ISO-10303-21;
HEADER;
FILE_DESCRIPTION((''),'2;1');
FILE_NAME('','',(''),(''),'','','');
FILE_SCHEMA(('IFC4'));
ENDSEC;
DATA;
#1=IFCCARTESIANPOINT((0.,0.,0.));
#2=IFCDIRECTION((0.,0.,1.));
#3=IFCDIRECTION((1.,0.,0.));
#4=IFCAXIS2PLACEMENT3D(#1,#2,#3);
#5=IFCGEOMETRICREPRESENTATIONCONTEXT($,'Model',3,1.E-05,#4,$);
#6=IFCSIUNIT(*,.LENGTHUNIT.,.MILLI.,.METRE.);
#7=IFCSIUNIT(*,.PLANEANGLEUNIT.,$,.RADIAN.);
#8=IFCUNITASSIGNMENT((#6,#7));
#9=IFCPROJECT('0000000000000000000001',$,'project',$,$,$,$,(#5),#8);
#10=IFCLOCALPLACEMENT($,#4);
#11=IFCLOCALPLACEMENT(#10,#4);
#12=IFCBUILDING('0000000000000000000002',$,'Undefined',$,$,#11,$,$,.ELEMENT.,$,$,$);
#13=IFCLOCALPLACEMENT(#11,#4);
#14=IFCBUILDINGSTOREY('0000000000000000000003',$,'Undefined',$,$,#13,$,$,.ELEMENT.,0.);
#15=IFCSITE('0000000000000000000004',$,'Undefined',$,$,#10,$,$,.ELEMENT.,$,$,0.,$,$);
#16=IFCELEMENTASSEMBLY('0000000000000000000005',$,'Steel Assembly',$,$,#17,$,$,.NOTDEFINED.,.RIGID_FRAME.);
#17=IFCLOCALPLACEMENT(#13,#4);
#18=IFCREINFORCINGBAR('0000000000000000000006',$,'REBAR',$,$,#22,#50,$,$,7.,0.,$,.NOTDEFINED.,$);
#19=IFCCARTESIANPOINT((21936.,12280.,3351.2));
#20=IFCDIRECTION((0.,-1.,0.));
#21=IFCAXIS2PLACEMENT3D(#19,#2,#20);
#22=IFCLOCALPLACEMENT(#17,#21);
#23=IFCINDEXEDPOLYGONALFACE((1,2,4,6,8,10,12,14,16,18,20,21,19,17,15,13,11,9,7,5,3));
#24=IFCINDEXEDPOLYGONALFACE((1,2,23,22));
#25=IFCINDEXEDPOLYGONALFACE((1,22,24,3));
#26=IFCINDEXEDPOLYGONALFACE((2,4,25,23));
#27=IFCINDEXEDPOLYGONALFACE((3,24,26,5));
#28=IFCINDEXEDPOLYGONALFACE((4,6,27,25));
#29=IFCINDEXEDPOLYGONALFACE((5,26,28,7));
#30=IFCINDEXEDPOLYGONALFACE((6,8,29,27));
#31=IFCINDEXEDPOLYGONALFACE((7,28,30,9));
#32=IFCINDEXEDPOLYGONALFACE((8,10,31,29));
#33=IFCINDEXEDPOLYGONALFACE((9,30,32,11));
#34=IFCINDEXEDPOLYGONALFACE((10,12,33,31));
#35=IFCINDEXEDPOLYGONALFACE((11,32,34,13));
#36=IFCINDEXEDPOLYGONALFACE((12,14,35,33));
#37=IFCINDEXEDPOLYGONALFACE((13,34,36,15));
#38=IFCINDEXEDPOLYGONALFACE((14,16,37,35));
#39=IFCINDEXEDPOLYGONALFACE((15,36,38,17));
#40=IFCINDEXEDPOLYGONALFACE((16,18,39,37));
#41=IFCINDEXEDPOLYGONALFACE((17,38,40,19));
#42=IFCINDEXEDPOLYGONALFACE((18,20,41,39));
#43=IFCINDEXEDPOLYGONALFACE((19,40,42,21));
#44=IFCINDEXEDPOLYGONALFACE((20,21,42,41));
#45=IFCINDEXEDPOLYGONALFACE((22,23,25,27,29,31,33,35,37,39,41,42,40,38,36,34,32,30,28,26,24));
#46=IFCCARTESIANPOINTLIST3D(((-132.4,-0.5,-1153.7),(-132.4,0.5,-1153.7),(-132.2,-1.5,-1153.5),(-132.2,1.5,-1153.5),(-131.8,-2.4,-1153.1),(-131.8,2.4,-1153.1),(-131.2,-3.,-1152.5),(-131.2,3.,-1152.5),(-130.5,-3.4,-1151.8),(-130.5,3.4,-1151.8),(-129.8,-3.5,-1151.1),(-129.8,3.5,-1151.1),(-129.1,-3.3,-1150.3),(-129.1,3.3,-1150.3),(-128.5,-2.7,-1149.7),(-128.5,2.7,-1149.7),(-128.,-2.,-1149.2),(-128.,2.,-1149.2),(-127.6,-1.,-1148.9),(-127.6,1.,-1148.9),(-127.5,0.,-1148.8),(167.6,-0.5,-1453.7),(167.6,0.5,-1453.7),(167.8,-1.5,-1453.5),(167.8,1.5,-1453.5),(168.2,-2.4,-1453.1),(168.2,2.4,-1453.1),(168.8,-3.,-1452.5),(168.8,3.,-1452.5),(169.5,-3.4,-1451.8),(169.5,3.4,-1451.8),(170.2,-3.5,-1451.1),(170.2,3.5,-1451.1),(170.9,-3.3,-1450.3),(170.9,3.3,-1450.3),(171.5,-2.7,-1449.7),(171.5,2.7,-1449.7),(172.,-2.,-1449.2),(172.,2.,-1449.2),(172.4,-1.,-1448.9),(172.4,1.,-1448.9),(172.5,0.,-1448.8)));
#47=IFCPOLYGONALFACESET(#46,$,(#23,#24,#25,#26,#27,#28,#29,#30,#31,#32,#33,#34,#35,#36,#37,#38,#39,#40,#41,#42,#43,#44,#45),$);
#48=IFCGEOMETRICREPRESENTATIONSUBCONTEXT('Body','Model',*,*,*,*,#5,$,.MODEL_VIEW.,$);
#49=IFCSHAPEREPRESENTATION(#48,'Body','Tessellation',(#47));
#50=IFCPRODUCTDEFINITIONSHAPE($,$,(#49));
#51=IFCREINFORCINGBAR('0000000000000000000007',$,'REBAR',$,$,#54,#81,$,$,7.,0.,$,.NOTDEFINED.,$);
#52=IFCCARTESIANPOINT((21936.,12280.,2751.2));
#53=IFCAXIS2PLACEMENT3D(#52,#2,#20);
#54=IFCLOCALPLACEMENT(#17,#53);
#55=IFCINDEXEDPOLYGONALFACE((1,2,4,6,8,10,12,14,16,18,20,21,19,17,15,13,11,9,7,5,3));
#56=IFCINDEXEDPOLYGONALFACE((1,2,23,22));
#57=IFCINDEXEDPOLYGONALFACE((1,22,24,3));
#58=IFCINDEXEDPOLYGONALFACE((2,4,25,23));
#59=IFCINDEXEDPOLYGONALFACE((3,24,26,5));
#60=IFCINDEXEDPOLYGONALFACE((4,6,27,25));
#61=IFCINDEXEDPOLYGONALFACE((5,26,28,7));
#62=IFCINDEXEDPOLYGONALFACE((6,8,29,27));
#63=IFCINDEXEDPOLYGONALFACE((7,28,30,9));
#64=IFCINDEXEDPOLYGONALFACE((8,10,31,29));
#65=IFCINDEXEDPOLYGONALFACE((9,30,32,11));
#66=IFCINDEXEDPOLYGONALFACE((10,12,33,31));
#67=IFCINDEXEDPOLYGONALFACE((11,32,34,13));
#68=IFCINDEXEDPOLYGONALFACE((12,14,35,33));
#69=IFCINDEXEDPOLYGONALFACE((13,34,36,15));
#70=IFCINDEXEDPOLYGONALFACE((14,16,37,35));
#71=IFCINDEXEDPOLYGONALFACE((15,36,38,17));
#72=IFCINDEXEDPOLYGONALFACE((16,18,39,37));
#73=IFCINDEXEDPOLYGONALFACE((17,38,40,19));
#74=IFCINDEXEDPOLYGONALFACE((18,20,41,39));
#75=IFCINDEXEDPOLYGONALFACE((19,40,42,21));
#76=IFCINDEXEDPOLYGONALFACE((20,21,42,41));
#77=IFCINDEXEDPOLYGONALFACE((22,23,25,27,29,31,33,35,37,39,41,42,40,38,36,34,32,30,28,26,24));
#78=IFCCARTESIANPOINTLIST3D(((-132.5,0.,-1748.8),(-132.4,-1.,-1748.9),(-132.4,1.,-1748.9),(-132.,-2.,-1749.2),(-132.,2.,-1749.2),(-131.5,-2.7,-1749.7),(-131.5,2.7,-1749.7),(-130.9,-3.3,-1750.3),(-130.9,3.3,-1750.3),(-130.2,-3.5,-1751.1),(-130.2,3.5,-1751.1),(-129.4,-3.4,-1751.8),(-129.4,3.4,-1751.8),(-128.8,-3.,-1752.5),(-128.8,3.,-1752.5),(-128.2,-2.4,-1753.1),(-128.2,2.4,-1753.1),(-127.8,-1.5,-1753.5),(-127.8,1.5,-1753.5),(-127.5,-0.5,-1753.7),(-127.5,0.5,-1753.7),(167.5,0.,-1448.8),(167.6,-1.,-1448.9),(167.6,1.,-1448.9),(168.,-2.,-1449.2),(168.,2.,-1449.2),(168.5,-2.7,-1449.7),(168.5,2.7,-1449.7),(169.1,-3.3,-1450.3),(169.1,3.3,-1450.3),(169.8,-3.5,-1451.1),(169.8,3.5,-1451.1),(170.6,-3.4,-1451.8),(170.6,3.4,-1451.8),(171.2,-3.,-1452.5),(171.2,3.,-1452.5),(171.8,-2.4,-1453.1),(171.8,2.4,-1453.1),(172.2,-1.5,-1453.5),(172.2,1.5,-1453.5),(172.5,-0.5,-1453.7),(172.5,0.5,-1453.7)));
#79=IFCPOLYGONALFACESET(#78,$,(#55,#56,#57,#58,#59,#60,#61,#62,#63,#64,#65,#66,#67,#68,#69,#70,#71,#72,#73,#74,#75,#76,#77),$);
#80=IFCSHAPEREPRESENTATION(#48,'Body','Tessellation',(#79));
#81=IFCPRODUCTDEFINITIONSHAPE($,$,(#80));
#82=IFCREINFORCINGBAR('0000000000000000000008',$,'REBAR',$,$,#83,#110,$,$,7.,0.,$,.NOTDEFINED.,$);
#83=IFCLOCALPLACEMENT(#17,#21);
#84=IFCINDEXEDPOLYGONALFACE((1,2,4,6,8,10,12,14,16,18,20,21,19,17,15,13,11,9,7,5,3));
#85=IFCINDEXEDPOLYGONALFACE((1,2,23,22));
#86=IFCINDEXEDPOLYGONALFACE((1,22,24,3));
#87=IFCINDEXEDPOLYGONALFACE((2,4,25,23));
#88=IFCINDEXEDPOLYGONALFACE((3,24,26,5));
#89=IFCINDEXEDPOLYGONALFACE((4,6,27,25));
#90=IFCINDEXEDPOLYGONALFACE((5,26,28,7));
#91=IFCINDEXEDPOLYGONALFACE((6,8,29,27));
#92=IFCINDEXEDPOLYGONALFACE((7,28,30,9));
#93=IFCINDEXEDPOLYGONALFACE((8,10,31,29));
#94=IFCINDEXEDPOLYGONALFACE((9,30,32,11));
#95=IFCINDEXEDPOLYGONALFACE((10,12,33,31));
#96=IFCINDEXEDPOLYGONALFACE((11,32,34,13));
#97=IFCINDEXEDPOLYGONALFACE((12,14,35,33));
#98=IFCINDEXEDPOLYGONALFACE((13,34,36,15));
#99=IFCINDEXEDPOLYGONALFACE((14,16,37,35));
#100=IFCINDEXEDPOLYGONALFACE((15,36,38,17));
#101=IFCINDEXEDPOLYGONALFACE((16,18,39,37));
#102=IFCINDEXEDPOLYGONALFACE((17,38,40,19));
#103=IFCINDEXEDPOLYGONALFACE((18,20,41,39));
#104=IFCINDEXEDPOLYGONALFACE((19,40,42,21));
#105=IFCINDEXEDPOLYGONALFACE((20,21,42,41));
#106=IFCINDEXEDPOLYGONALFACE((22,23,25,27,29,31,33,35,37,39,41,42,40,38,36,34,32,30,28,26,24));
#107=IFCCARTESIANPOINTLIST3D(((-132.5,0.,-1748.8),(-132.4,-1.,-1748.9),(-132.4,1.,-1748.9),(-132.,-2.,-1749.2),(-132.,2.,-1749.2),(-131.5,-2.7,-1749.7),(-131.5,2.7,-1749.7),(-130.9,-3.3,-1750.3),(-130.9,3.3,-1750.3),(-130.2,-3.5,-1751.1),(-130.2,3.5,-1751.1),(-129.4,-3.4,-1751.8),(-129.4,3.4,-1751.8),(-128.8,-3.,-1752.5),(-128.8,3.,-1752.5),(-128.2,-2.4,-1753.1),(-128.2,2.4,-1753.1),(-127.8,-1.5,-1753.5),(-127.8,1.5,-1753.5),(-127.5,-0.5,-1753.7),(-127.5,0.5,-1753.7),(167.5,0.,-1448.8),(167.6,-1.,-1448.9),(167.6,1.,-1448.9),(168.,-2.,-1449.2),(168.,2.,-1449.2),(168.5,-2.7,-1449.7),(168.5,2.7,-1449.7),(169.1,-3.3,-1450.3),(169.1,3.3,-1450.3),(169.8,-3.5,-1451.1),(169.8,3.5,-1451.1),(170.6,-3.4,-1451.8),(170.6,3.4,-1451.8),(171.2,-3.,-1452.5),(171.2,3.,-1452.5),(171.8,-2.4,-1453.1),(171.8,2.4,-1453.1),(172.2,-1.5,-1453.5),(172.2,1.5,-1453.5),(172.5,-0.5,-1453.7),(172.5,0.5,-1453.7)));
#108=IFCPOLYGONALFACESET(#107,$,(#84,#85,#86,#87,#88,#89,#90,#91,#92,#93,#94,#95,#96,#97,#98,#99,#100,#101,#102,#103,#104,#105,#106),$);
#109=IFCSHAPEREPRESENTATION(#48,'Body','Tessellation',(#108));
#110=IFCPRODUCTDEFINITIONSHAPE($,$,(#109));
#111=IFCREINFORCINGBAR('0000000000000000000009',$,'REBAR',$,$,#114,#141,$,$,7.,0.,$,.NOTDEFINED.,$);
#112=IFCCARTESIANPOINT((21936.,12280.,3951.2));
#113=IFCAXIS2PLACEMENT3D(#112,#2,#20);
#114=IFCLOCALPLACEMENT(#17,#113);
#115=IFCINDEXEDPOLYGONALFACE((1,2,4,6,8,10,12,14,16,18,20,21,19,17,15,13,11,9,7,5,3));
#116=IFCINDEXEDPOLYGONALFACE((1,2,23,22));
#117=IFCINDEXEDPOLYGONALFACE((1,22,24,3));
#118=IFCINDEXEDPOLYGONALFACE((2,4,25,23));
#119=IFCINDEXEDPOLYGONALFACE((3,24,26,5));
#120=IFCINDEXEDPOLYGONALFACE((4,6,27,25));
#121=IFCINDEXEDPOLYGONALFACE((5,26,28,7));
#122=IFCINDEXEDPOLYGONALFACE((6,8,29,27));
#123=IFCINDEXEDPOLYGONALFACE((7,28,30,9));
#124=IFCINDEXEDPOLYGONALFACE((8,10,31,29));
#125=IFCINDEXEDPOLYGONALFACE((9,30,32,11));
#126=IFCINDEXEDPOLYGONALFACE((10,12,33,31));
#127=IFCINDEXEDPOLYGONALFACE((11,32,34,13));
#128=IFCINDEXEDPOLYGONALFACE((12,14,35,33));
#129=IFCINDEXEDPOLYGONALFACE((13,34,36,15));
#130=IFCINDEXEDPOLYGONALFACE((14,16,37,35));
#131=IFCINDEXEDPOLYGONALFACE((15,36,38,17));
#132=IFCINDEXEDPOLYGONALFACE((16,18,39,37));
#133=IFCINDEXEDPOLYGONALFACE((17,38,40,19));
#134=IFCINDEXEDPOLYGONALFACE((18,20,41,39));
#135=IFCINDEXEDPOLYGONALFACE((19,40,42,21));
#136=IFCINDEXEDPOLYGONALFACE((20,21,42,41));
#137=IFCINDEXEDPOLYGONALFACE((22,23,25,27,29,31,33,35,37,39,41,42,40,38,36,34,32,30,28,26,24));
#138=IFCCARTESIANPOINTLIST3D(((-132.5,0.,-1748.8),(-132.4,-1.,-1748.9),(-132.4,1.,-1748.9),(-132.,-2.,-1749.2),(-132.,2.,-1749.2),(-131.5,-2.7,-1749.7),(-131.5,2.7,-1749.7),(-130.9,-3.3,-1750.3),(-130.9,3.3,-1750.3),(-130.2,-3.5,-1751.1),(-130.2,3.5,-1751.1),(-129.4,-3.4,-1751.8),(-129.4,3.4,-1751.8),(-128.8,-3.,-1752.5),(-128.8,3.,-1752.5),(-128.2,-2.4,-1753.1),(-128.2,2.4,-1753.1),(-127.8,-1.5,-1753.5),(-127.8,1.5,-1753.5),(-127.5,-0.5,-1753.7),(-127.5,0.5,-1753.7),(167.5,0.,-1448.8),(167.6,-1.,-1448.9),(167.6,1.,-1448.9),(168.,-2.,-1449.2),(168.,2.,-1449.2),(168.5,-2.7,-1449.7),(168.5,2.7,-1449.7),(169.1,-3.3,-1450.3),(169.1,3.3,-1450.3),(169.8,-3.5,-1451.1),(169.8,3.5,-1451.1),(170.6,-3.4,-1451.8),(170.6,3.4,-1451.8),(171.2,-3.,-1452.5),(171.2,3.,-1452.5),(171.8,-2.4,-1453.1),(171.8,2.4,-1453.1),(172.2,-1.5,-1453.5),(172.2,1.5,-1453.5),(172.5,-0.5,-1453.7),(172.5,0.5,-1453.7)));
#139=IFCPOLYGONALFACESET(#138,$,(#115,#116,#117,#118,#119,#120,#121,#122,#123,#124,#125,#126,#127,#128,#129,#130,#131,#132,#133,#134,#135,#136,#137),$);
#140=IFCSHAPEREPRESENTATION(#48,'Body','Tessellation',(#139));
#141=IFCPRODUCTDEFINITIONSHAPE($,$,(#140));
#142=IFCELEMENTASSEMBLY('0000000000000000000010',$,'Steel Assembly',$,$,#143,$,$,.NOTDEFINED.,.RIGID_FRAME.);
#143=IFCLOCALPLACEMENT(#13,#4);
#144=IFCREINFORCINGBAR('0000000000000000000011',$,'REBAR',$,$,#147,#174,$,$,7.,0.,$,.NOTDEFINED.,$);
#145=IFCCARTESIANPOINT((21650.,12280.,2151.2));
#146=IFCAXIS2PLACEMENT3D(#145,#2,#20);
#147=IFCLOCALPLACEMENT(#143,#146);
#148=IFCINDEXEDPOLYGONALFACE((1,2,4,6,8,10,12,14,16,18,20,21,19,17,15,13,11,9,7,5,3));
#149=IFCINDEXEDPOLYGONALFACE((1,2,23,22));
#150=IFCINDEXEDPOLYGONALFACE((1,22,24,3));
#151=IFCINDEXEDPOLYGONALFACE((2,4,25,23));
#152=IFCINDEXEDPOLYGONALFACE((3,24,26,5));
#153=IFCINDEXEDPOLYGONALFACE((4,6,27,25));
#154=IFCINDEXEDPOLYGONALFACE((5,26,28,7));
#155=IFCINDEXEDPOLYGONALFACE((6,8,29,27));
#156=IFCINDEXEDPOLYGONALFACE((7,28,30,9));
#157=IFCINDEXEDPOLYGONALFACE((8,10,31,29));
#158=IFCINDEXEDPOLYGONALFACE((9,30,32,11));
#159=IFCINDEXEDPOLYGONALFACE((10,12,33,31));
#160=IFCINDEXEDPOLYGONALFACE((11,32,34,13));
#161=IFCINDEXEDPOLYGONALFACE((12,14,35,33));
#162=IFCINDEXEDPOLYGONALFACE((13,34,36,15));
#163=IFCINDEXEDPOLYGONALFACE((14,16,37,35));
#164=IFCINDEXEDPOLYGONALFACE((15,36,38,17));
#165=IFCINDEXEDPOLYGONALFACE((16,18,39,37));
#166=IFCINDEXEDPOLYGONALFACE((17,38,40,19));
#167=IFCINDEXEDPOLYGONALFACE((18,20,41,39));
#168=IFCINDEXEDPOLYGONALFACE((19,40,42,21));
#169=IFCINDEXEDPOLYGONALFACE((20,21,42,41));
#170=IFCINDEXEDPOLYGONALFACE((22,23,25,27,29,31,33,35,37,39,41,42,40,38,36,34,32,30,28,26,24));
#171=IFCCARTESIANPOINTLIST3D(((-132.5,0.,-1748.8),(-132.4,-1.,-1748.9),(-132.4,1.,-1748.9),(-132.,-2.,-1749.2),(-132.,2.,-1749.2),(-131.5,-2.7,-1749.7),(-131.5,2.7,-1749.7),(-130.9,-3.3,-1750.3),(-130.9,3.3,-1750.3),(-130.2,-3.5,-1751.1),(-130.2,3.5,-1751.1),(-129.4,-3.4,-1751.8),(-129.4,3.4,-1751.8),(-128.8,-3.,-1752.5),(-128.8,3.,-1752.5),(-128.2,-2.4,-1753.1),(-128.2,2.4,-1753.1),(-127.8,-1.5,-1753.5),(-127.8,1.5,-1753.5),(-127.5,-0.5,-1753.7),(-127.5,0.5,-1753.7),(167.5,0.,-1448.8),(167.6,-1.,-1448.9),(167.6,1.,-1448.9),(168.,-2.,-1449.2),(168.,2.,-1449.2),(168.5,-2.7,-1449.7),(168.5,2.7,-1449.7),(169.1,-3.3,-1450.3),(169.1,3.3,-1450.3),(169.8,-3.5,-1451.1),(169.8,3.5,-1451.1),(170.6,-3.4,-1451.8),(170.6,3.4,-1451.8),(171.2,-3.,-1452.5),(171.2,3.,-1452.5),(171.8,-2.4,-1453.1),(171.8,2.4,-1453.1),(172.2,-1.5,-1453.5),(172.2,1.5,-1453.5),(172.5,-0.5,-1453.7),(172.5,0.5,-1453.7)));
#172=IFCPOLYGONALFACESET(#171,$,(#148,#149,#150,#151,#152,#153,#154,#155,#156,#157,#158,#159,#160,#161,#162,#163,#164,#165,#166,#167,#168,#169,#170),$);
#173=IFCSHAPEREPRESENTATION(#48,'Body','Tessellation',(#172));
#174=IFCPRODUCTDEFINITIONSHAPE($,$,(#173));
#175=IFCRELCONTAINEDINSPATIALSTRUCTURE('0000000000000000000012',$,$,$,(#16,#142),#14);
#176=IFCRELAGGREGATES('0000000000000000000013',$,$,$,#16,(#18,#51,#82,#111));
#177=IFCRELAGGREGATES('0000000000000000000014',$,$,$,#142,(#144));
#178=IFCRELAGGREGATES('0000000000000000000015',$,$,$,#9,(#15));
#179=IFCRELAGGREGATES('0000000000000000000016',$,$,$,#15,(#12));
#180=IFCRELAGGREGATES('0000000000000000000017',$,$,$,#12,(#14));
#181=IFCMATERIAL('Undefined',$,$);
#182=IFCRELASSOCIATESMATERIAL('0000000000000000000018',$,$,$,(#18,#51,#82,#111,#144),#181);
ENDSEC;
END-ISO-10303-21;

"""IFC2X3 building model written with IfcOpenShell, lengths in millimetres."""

from ifc_helpers import new_model, entity, si_unit, frame, origin_with_axes, place, context, subcontext, project, spatial, source, transform, mapped, material, element, aggregate, save


model = new_model("IFC2X3")

# Units and contexts
model_context = context("Model", 3, precision=1e-05, world=origin_with_axes())
body_context = subcontext(model_context, "Body", "Model", "MODEL_VIEW")
ifc_project = project(units=[si_unit("LENGTHUNIT", "METRE", prefix="MILLI"), si_unit("PLANEANGLEUNIT", "RADIAN")], contexts=[model_context])

# Site, building, storey
site_placement = place(None, origin_with_axes())
site = spatial("IfcSite", under=ifc_project, at=site_placement, Name="Undefined", CompositionType="ELEMENT", RefElevation=0.0)
building_placement = place(site_placement, origin_with_axes())
building = spatial("IfcBuilding", under=site, at=building_placement, Name="Undefined", CompositionType="ELEMENT")
storey_placement = place(building_placement, origin_with_axes())
storey = spatial("IfcBuildingStorey", under=building, at=storey_placement, Name="Undefined", CompositionType="ELEMENT", Elevation=0.0)

# Shared definitions
ifc_material_1 = material(Name="Undefined")

# Element assemblies, reinforcing bars
assembly_1_placement = place(storey_placement, origin_with_axes())
assembly_1 = element("IfcElementAssembly", 1, at=assembly_1_placement, inside=storey, Name="Steel Assembly", AssemblyPlace="NOTDEFINED", PredefinedType="RIGID_FRAME")
shared_shape_1 = source(origin_with_axes(), body_context, "Body", "AdvancedSweptSolid", [
    entity("IfcSweptDiskSolid", entity("IfcTrimmedCurve", entity("IfcLine", entity("IfcCartesianPoint", [0.0, 0.0, 0.0]), entity("IfcVector", entity("IfcDirection", [0.707107, 0.0, -0.707107]), 1.0)), [entity("IfcParameterValue", 0.0)], [entity("IfcParameterValue", 424.264069)], True, "PARAMETER"), 3.5, None, 0.0, 424.3),
])
reinforcing_bar_1_placement = place(assembly_1_placement, frame((21936.0, 12280.0, 3351.2), z_axis=(0.0, 0.0, 1.0), x_axis=(0.0, -1.0, 0.0)))
reinforcing_bar_1 = element("IfcReinforcingBar", 2, at=reinforcing_bar_1_placement, material=ifc_material_1, Name="REBAR", BarRole="NOTDEFINED", CrossSectionArea=0.0, NominalDiameter=7.0, context=body_context, shape_type="MappedRepresentation", body=[
    mapped(shared_shape_1, transform((-130.0, 0.0, -1151.2))),
])
shared_shape_2 = source(origin_with_axes(), body_context, "Body", "AdvancedSweptSolid", [
    entity("IfcSweptDiskSolid", entity("IfcTrimmedCurve", entity("IfcLine", entity("IfcCartesianPoint", [0.0, 0.0, 0.0]), entity("IfcVector", entity("IfcDirection", [0.707107, 0.0, 0.707107]), 1.0)), [entity("IfcParameterValue", 0.0)], [entity("IfcParameterValue", 424.264069)], True, "PARAMETER"), 3.5, None, 0.0, 424.3),
])
reinforcing_bar_2_placement = place(assembly_1_placement, frame((21936.0, 12280.0, 2751.2), z_axis=(0.0, 0.0, 1.0), x_axis=(0.0, -1.0, 0.0)))
reinforcing_bar_2 = element("IfcReinforcingBar", 3, at=reinforcing_bar_2_placement, material=ifc_material_1, Name="REBAR", BarRole="NOTDEFINED", CrossSectionArea=0.0, NominalDiameter=7.0, context=body_context, shape_type="MappedRepresentation", body=[
    mapped(shared_shape_2, transform((-130.0, 0.0, -1751.2))),
])
shared_shape_3 = source(origin_with_axes(), body_context, "Body", "AdvancedSweptSolid", [
    entity("IfcSweptDiskSolid", entity("IfcTrimmedCurve", entity("IfcLine", entity("IfcCartesianPoint", [0.0, 0.0, 0.0]), entity("IfcVector", entity("IfcDirection", [0.707107, 0.0, 0.707107]), 1.0)), [entity("IfcParameterValue", 0.0)], [entity("IfcParameterValue", 424.264069)], True, "PARAMETER"), 3.5, None, 0.0, 424.3),
])
reinforcing_bar_3_placement = place(assembly_1_placement, frame((21936.0, 12280.0, 3351.2), z_axis=(0.0, 0.0, 1.0), x_axis=(0.0, -1.0, 0.0)))
reinforcing_bar_3 = element("IfcReinforcingBar", 4, at=reinforcing_bar_3_placement, material=ifc_material_1, Name="REBAR", BarRole="NOTDEFINED", CrossSectionArea=0.0, NominalDiameter=7.0, context=body_context, shape_type="MappedRepresentation", body=[
    mapped(shared_shape_3, transform((-130.0, 0.0, -1751.2))),
])
shared_shape_4 = source(origin_with_axes(), body_context, "Body", "AdvancedSweptSolid", [
    entity("IfcSweptDiskSolid", entity("IfcTrimmedCurve", entity("IfcLine", entity("IfcCartesianPoint", [0.0, 0.0, 0.0]), entity("IfcVector", entity("IfcDirection", [0.707107, 0.0, 0.707107]), 1.0)), [entity("IfcParameterValue", 0.0)], [entity("IfcParameterValue", 424.264069)], True, "PARAMETER"), 3.5, None, 0.0, 424.3),
])
reinforcing_bar_4_placement = place(assembly_1_placement, frame((21936.0, 12280.0, 3951.2), z_axis=(0.0, 0.0, 1.0), x_axis=(0.0, -1.0, 0.0)))
reinforcing_bar_4 = element("IfcReinforcingBar", 5, at=reinforcing_bar_4_placement, material=ifc_material_1, Name="REBAR", BarRole="NOTDEFINED", CrossSectionArea=0.0, NominalDiameter=7.0, context=body_context, shape_type="MappedRepresentation", body=[
    mapped(shared_shape_4, transform((-130.0, 0.0, -1751.2))),
])
aggregate(assembly_1, [reinforcing_bar_1, reinforcing_bar_2, reinforcing_bar_3, reinforcing_bar_4])
assembly_2_placement = place(storey_placement, origin_with_axes())
assembly_2 = element("IfcElementAssembly", 6, at=assembly_2_placement, inside=storey, Name="Steel Assembly", AssemblyPlace="NOTDEFINED", PredefinedType="RIGID_FRAME")
shared_shape_5 = source(origin_with_axes(), body_context, "Body", "AdvancedSweptSolid", [
    entity("IfcSweptDiskSolid", entity("IfcTrimmedCurve", entity("IfcLine", entity("IfcCartesianPoint", [0.0, 0.0, 0.0]), entity("IfcVector", entity("IfcDirection", [0.707107, 0.0, 0.707107]), 1.0)), [entity("IfcParameterValue", 0.0)], [entity("IfcParameterValue", 424.264069)], True, "PARAMETER"), 3.5, None, 0.0, 424.3),
])
reinforcing_bar_5_placement = place(assembly_2_placement, frame((21650.0, 12280.0, 2151.2), z_axis=(0.0, 0.0, 1.0), x_axis=(0.0, -1.0, 0.0)))
reinforcing_bar_5 = element("IfcReinforcingBar", 7, at=reinforcing_bar_5_placement, material=ifc_material_1, Name="REBAR", BarRole="NOTDEFINED", CrossSectionArea=0.0, NominalDiameter=7.0, context=body_context, shape_type="MappedRepresentation", body=[
    mapped(shared_shape_5, transform((-130.0, 0.0, -1751.2))),
])
aggregate(assembly_2, [reinforcing_bar_5])

save(model, "model.ifc")
